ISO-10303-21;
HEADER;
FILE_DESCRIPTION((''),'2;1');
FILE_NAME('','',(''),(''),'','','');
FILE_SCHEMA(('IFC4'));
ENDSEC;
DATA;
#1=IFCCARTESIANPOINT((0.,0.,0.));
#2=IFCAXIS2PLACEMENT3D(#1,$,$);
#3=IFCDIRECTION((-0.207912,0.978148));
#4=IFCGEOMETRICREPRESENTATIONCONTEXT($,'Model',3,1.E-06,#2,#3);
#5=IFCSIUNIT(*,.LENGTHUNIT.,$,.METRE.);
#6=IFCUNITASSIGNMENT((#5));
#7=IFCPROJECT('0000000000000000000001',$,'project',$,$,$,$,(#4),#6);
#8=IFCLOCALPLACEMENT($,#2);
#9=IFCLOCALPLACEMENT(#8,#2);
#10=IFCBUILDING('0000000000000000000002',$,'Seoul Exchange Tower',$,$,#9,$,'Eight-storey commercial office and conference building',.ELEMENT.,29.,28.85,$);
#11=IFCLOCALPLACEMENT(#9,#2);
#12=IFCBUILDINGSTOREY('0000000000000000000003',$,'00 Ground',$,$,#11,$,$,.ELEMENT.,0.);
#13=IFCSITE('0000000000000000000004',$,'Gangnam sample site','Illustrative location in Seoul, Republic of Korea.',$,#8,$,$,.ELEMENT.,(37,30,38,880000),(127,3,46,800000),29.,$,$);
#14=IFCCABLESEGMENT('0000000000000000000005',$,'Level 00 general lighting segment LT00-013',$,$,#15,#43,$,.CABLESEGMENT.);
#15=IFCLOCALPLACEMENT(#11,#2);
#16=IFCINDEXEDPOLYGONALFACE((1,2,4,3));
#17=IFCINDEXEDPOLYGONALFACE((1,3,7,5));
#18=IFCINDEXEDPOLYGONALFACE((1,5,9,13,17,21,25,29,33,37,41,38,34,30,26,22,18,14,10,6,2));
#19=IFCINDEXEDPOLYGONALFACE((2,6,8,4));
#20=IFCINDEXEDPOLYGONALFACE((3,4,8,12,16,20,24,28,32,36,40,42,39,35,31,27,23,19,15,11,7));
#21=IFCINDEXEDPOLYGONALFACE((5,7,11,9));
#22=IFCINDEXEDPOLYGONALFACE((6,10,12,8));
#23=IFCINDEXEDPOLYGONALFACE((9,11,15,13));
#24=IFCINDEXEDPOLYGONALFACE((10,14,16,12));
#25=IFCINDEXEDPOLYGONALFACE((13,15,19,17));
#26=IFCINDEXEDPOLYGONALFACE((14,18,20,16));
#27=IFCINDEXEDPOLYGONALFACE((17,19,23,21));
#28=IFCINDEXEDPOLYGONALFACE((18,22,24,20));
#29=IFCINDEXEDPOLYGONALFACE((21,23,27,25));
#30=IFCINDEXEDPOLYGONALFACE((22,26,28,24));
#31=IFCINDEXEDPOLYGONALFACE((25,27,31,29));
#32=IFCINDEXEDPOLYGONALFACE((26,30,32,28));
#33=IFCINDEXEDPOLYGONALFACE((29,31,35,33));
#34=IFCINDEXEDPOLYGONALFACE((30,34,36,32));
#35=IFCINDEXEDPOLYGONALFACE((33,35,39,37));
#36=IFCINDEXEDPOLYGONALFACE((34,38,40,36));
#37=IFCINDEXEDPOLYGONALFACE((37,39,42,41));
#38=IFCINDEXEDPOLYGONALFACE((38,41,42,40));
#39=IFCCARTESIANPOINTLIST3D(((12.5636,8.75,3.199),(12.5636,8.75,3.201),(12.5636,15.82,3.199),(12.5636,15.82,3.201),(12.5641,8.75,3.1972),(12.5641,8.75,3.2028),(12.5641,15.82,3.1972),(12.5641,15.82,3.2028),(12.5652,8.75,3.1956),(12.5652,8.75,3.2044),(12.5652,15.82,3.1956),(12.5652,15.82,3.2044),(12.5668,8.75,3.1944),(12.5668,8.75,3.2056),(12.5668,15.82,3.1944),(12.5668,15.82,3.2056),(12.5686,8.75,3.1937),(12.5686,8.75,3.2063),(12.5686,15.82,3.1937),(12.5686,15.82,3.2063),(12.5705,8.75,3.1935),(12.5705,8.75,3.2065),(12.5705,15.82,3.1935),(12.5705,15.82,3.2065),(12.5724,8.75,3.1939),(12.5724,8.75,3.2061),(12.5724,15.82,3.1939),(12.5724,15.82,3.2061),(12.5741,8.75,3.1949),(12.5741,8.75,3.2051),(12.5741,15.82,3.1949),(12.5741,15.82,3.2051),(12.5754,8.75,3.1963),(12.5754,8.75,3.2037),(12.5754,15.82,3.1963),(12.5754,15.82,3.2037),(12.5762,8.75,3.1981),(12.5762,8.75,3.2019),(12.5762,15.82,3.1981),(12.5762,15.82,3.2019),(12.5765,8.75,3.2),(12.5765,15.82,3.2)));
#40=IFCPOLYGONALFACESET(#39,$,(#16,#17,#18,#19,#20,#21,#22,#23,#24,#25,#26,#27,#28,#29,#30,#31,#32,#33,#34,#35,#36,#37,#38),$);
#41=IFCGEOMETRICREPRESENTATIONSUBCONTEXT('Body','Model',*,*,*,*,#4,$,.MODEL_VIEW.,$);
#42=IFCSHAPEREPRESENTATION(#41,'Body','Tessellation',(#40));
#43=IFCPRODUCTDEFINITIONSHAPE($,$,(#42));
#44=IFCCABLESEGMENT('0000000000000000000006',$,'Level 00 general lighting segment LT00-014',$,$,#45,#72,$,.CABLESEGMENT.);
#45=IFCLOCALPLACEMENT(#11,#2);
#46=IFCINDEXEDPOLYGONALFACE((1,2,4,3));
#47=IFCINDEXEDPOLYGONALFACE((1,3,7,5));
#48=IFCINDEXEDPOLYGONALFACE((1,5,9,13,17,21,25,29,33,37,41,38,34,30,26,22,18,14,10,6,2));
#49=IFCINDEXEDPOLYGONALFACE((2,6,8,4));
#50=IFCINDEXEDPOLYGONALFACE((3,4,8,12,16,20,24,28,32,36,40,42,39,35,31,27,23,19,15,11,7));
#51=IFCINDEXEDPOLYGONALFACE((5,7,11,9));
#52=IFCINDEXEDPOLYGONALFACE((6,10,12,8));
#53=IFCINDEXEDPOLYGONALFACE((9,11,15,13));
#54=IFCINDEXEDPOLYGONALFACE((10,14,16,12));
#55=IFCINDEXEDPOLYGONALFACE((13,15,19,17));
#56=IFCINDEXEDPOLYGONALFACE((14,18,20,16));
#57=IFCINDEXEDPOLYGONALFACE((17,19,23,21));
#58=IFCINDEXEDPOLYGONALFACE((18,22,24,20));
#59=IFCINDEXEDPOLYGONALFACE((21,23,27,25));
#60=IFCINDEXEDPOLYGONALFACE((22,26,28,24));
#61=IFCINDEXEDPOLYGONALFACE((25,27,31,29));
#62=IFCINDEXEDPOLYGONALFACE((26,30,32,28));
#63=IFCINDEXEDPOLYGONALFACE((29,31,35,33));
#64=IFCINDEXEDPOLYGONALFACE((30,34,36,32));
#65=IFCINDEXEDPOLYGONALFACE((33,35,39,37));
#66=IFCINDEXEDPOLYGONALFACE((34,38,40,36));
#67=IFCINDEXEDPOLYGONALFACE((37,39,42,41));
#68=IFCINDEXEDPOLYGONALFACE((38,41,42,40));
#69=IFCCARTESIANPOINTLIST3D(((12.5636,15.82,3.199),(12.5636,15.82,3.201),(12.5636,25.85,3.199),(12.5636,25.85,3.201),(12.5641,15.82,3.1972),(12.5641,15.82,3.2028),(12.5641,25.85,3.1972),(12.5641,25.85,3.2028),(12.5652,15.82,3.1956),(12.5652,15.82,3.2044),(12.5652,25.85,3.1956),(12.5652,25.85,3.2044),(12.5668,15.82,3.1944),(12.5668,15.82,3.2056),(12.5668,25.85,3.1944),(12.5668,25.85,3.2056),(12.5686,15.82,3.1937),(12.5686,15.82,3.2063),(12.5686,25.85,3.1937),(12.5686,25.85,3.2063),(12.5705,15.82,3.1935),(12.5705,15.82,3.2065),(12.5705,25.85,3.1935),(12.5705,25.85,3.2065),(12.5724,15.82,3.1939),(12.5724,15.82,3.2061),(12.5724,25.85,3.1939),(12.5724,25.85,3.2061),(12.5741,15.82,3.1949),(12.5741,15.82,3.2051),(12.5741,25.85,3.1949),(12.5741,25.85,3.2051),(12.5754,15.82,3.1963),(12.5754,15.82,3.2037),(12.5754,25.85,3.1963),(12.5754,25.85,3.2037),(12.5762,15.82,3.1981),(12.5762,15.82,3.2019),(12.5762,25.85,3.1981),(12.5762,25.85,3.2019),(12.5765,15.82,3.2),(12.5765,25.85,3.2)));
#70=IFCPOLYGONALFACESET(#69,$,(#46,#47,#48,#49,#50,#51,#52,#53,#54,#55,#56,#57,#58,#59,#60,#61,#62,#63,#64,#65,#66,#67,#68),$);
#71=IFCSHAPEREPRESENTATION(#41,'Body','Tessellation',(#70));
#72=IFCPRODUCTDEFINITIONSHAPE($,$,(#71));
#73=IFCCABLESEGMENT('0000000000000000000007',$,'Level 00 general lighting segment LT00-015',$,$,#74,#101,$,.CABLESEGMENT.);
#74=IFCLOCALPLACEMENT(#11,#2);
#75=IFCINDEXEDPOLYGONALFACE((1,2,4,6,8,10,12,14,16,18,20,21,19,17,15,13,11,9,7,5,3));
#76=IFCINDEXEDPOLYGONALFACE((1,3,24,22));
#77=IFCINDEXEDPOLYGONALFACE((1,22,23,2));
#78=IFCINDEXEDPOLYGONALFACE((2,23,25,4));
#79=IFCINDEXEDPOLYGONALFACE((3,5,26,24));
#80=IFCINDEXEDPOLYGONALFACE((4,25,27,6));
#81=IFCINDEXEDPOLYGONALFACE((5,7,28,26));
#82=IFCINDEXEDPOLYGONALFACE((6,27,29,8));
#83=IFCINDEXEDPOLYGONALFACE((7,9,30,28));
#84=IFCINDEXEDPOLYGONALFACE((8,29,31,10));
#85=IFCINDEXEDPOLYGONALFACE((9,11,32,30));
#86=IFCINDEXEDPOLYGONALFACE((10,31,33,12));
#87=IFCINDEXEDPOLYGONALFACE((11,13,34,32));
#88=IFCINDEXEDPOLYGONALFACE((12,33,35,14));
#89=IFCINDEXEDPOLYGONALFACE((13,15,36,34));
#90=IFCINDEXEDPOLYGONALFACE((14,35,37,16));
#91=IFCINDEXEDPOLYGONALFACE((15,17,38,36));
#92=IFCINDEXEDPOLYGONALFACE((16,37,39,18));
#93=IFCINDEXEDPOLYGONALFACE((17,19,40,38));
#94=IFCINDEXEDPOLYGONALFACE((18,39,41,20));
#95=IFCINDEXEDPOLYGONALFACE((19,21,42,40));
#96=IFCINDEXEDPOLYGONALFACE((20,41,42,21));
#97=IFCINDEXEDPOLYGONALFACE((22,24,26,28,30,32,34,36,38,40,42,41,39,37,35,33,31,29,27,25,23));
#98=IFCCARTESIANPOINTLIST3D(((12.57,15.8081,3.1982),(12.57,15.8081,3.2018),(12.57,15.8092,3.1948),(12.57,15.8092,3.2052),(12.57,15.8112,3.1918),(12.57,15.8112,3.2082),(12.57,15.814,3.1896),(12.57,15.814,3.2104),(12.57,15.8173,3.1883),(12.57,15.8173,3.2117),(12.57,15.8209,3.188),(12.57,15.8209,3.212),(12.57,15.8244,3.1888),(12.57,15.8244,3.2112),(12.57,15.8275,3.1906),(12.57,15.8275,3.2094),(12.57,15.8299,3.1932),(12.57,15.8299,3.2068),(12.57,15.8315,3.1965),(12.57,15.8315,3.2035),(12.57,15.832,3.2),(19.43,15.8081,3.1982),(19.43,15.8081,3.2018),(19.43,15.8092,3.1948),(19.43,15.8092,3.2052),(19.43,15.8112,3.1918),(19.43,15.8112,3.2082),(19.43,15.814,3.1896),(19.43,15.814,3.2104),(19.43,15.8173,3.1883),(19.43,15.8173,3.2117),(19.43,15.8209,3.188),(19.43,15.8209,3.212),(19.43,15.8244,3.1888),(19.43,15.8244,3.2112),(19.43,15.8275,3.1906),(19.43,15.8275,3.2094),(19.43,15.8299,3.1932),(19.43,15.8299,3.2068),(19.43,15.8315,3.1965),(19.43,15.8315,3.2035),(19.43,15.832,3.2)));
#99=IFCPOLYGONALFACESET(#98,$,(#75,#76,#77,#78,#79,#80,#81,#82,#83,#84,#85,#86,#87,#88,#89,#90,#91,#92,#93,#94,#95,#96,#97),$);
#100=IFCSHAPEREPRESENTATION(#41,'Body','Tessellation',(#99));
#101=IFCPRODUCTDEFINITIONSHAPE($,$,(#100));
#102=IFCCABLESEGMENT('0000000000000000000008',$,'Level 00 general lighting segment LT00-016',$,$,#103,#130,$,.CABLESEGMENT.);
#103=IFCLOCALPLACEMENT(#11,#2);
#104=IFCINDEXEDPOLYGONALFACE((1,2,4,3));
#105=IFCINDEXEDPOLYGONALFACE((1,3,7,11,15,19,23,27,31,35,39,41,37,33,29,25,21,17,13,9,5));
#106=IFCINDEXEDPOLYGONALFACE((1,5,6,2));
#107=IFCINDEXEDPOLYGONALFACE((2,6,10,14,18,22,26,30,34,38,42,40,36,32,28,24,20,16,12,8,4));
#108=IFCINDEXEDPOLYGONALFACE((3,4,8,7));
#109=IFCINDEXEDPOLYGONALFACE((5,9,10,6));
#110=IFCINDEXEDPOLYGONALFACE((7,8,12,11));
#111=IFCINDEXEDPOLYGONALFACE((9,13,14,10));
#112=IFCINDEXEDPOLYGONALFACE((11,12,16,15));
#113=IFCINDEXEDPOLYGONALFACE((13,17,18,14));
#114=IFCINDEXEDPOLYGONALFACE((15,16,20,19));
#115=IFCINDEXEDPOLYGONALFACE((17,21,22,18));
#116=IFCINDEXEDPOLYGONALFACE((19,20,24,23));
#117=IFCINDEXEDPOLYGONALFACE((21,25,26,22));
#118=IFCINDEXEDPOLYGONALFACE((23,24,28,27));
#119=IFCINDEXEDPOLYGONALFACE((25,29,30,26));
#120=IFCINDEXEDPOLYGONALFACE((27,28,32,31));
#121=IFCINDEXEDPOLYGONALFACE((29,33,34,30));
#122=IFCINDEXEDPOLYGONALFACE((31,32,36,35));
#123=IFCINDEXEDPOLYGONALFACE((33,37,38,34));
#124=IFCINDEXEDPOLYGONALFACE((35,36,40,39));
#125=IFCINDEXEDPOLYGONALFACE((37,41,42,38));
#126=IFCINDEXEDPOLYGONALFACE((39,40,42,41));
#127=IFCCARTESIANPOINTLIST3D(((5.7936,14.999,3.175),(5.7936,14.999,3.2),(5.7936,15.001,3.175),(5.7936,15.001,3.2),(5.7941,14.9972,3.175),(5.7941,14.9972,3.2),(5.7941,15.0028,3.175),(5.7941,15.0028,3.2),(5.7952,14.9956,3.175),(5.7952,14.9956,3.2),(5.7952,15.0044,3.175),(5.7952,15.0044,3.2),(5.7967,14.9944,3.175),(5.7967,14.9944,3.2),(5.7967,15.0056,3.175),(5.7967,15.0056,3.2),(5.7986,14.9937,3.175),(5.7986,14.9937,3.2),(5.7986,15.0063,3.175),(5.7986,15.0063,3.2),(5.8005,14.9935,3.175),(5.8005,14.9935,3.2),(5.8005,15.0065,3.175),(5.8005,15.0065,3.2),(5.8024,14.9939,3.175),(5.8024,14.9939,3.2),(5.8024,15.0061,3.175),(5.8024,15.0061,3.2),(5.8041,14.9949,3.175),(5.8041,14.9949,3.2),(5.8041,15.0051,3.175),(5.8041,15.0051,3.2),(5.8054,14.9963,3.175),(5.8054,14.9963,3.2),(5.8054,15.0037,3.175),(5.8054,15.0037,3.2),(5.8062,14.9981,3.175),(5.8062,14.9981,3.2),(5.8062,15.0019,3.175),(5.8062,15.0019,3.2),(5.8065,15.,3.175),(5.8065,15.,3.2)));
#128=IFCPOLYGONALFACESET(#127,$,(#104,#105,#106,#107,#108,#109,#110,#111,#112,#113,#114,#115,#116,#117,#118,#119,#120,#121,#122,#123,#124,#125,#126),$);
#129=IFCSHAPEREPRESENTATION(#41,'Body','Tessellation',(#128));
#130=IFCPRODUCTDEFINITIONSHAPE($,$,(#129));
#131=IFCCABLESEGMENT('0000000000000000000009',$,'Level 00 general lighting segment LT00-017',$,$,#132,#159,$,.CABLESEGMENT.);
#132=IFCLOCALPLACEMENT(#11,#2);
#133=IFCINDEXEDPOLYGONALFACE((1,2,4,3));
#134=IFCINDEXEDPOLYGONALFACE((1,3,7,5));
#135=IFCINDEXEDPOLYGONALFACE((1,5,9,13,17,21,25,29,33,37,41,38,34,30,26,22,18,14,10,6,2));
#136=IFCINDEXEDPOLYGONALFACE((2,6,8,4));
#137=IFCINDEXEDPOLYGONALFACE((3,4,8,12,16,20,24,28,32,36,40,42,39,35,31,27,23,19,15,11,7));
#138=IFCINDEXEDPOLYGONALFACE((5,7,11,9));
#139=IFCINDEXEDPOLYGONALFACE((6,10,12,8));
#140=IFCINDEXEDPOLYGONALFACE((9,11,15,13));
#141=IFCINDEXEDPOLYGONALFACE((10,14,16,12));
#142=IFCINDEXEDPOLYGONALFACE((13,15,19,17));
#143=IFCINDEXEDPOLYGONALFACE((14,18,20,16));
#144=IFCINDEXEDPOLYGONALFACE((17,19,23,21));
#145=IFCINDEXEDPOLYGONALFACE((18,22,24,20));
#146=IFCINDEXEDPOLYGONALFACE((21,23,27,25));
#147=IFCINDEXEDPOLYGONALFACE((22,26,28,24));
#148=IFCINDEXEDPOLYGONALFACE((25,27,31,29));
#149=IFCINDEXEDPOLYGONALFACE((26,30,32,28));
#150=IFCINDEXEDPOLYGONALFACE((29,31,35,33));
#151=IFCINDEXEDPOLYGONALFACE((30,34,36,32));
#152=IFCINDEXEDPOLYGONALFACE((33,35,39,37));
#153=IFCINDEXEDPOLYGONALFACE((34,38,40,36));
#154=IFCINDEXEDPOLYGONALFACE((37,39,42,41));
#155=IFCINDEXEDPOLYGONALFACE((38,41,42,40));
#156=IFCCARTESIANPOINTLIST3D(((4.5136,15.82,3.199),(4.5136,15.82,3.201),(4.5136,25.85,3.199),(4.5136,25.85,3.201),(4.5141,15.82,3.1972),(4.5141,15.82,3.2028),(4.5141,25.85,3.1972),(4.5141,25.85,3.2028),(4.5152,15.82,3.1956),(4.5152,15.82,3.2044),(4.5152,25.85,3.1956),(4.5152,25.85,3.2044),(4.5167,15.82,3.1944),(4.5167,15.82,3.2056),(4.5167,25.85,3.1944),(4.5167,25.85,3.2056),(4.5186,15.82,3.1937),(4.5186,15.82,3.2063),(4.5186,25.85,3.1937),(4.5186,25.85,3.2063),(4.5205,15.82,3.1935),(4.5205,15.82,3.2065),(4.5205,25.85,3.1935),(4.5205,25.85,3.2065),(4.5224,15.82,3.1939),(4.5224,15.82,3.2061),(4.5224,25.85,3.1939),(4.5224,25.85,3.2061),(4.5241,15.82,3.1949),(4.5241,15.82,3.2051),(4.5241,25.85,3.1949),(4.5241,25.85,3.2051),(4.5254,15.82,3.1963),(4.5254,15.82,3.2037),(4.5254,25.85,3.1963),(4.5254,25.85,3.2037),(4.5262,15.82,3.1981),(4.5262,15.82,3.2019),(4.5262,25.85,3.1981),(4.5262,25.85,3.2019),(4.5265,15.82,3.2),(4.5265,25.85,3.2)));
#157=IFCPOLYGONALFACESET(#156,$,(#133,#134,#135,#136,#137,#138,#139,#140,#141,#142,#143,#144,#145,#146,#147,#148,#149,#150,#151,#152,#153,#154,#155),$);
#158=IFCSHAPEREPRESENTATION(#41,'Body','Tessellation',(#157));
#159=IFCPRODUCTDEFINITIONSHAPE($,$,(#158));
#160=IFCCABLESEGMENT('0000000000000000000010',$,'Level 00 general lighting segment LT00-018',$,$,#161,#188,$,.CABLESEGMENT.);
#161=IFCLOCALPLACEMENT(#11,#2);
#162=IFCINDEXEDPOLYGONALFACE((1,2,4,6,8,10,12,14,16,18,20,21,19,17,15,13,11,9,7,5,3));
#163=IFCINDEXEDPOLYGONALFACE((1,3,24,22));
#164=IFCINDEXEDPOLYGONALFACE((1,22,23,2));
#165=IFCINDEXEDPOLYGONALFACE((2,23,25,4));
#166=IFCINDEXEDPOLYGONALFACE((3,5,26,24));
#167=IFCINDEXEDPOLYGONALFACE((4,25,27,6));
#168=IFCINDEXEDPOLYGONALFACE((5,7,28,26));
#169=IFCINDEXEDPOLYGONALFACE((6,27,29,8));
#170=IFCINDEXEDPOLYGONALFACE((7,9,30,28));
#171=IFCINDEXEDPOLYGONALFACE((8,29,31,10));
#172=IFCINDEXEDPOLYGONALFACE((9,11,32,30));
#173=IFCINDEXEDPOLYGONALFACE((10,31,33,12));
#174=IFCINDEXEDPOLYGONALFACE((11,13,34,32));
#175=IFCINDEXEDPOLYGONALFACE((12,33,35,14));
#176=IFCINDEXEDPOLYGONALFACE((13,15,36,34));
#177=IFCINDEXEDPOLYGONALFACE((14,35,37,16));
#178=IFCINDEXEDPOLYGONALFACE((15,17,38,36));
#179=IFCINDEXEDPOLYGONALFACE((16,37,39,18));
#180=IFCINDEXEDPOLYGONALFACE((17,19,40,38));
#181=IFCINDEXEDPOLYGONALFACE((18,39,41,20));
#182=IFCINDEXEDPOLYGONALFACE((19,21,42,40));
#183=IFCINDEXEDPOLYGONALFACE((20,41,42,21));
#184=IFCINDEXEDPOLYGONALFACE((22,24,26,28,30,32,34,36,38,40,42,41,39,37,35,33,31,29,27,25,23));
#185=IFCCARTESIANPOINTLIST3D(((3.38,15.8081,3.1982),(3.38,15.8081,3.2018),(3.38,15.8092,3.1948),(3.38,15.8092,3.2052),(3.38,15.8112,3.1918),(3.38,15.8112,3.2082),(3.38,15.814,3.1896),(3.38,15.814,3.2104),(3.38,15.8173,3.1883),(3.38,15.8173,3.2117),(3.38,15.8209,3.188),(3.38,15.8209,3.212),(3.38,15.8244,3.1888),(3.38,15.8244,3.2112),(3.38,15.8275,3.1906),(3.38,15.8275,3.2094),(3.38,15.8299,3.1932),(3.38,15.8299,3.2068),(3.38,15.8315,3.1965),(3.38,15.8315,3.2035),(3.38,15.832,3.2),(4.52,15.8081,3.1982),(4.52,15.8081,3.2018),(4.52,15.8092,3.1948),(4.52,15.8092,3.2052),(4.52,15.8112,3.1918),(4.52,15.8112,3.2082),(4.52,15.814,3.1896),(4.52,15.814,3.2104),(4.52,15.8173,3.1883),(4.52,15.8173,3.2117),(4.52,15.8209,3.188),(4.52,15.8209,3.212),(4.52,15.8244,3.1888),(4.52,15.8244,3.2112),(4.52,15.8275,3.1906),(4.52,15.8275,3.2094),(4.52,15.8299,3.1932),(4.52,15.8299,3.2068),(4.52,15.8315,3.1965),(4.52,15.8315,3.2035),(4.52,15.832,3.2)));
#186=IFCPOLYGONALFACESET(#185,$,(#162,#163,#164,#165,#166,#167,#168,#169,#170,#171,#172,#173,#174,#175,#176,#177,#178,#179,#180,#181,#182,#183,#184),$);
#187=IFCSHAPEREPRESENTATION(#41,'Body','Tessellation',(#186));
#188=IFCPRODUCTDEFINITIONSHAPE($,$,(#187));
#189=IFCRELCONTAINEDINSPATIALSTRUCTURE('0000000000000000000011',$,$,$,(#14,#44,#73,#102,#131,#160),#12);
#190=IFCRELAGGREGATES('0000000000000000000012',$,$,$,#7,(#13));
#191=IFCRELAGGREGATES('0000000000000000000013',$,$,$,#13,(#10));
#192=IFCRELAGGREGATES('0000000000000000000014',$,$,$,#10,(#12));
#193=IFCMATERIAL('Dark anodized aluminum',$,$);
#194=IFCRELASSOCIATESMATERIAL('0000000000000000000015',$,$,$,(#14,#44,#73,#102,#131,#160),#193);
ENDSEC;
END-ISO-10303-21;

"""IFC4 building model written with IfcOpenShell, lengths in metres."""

from ifc_helpers import new_model, si_unit, direction, frame, origin, place, context, subcontext, project, spatial, circle, extrude, material, element, save


model = new_model("IFC4")

# Units and contexts
model_context = context("Model", 3, precision=1e-06, world=origin(), true_north=direction((-0.207912, 0.978148)))
body_context = subcontext(model_context, "Body", "Model", "MODEL_VIEW")
ifc_project = project(units=[si_unit("LENGTHUNIT", "METRE")], contexts=[model_context])

# Site, building, storey
site_placement = place(None, origin())
site = spatial("IfcSite", under=ifc_project, at=site_placement, Name="Gangnam sample site", Description="Illustrative location in Seoul, Republic of Korea.", CompositionType="ELEMENT", RefLatitude=(37, 30, 38, 880000), RefLongitude=(127, 3, 46, 800000), RefElevation=29.0)
building_placement = place(site_placement, origin())
building = spatial("IfcBuilding", under=site, at=building_placement, Name="Seoul Exchange Tower", LongName="Eight-storey commercial office and conference building", CompositionType="ELEMENT", ElevationOfRefHeight=29.0, ElevationOfTerrain=28.85)
storey_placement = place(building_placement, origin())
storey = spatial("IfcBuildingStorey", under=building, at=storey_placement, Name="00 Ground", CompositionType="ELEMENT", Elevation=0.0)

# Shared definitions
ifc_material = material(Name="Dark anodized aluminum")
placement = place(storey_placement, origin())

# Cable segments
element("IfcCableSegment", 1, at=placement, inside=storey, material=ifc_material, Name="Level 00 general lighting segment LT00-013", PredefinedType="CABLESEGMENT", context=body_context, shape_type="SweptSolid", body=[
    extrude(circle(Radius=0.0065), frame((12.57, 15.82, 3.2), z_axis=(0.0, -1.0, 0.0), x_axis=(1.0, 0.0, 0.0)), (0.0, 0.0, 1.0), 7.07),
])
element("IfcCableSegment", 2, at=placement, inside=storey, material=ifc_material, Name="Level 00 general lighting segment LT00-014", PredefinedType="CABLESEGMENT", context=body_context, shape_type="SweptSolid", body=[
    extrude(circle(Radius=0.0065), frame((12.57, 15.82, 3.2), z_axis=(0.0, 1.0, 0.0), x_axis=(1.0, 0.0, 0.0)), (0.0, 0.0, 1.0), 10.03),
])
element("IfcCableSegment", 3, at=placement, inside=storey, material=ifc_material, Name="Level 00 general lighting segment LT00-015", PredefinedType="CABLESEGMENT", context=body_context, shape_type="SweptSolid", body=[
    extrude(circle(Radius=0.012), frame((12.57, 15.82, 3.2), z_axis=(1.0, 0.0, 0.0), x_axis=(0.0, 1.0, 0.0)), (0.0, 0.0, 1.0), 6.86),
])
element("IfcCableSegment", 4, at=placement, inside=storey, material=ifc_material, Name="Level 00 general lighting segment LT00-016", PredefinedType="CABLESEGMENT", context=body_context, shape_type="SweptSolid", body=[
    extrude(circle(Radius=0.0065), frame((5.8, 15.0, 3.2), z_axis=(0.0, 0.0, -1.0), x_axis=(1.0, 0.0, 0.0)), (0.0, 0.0, 1.0), 0.025),
])
element("IfcCableSegment", 5, at=placement, inside=storey, material=ifc_material, Name="Level 00 general lighting segment LT00-017", PredefinedType="CABLESEGMENT", context=body_context, shape_type="SweptSolid", body=[
    extrude(circle(Radius=0.0065), frame((4.52, 15.82, 3.2), z_axis=(0.0, 1.0, 0.0), x_axis=(1.0, 0.0, 0.0)), (0.0, 0.0, 1.0), 10.03),
])
element("IfcCableSegment", 6, at=placement, inside=storey, material=ifc_material, Name="Level 00 general lighting segment LT00-018", PredefinedType="CABLESEGMENT", context=body_context, shape_type="SweptSolid", body=[
    extrude(circle(Radius=0.012), frame((4.52, 15.82, 3.2), z_axis=(-1.0, 0.0, 0.0), x_axis=(0.0, 1.0, 0.0)), (0.0, 0.0, 1.0), 1.14),
])

save(model, "model.ifc")
